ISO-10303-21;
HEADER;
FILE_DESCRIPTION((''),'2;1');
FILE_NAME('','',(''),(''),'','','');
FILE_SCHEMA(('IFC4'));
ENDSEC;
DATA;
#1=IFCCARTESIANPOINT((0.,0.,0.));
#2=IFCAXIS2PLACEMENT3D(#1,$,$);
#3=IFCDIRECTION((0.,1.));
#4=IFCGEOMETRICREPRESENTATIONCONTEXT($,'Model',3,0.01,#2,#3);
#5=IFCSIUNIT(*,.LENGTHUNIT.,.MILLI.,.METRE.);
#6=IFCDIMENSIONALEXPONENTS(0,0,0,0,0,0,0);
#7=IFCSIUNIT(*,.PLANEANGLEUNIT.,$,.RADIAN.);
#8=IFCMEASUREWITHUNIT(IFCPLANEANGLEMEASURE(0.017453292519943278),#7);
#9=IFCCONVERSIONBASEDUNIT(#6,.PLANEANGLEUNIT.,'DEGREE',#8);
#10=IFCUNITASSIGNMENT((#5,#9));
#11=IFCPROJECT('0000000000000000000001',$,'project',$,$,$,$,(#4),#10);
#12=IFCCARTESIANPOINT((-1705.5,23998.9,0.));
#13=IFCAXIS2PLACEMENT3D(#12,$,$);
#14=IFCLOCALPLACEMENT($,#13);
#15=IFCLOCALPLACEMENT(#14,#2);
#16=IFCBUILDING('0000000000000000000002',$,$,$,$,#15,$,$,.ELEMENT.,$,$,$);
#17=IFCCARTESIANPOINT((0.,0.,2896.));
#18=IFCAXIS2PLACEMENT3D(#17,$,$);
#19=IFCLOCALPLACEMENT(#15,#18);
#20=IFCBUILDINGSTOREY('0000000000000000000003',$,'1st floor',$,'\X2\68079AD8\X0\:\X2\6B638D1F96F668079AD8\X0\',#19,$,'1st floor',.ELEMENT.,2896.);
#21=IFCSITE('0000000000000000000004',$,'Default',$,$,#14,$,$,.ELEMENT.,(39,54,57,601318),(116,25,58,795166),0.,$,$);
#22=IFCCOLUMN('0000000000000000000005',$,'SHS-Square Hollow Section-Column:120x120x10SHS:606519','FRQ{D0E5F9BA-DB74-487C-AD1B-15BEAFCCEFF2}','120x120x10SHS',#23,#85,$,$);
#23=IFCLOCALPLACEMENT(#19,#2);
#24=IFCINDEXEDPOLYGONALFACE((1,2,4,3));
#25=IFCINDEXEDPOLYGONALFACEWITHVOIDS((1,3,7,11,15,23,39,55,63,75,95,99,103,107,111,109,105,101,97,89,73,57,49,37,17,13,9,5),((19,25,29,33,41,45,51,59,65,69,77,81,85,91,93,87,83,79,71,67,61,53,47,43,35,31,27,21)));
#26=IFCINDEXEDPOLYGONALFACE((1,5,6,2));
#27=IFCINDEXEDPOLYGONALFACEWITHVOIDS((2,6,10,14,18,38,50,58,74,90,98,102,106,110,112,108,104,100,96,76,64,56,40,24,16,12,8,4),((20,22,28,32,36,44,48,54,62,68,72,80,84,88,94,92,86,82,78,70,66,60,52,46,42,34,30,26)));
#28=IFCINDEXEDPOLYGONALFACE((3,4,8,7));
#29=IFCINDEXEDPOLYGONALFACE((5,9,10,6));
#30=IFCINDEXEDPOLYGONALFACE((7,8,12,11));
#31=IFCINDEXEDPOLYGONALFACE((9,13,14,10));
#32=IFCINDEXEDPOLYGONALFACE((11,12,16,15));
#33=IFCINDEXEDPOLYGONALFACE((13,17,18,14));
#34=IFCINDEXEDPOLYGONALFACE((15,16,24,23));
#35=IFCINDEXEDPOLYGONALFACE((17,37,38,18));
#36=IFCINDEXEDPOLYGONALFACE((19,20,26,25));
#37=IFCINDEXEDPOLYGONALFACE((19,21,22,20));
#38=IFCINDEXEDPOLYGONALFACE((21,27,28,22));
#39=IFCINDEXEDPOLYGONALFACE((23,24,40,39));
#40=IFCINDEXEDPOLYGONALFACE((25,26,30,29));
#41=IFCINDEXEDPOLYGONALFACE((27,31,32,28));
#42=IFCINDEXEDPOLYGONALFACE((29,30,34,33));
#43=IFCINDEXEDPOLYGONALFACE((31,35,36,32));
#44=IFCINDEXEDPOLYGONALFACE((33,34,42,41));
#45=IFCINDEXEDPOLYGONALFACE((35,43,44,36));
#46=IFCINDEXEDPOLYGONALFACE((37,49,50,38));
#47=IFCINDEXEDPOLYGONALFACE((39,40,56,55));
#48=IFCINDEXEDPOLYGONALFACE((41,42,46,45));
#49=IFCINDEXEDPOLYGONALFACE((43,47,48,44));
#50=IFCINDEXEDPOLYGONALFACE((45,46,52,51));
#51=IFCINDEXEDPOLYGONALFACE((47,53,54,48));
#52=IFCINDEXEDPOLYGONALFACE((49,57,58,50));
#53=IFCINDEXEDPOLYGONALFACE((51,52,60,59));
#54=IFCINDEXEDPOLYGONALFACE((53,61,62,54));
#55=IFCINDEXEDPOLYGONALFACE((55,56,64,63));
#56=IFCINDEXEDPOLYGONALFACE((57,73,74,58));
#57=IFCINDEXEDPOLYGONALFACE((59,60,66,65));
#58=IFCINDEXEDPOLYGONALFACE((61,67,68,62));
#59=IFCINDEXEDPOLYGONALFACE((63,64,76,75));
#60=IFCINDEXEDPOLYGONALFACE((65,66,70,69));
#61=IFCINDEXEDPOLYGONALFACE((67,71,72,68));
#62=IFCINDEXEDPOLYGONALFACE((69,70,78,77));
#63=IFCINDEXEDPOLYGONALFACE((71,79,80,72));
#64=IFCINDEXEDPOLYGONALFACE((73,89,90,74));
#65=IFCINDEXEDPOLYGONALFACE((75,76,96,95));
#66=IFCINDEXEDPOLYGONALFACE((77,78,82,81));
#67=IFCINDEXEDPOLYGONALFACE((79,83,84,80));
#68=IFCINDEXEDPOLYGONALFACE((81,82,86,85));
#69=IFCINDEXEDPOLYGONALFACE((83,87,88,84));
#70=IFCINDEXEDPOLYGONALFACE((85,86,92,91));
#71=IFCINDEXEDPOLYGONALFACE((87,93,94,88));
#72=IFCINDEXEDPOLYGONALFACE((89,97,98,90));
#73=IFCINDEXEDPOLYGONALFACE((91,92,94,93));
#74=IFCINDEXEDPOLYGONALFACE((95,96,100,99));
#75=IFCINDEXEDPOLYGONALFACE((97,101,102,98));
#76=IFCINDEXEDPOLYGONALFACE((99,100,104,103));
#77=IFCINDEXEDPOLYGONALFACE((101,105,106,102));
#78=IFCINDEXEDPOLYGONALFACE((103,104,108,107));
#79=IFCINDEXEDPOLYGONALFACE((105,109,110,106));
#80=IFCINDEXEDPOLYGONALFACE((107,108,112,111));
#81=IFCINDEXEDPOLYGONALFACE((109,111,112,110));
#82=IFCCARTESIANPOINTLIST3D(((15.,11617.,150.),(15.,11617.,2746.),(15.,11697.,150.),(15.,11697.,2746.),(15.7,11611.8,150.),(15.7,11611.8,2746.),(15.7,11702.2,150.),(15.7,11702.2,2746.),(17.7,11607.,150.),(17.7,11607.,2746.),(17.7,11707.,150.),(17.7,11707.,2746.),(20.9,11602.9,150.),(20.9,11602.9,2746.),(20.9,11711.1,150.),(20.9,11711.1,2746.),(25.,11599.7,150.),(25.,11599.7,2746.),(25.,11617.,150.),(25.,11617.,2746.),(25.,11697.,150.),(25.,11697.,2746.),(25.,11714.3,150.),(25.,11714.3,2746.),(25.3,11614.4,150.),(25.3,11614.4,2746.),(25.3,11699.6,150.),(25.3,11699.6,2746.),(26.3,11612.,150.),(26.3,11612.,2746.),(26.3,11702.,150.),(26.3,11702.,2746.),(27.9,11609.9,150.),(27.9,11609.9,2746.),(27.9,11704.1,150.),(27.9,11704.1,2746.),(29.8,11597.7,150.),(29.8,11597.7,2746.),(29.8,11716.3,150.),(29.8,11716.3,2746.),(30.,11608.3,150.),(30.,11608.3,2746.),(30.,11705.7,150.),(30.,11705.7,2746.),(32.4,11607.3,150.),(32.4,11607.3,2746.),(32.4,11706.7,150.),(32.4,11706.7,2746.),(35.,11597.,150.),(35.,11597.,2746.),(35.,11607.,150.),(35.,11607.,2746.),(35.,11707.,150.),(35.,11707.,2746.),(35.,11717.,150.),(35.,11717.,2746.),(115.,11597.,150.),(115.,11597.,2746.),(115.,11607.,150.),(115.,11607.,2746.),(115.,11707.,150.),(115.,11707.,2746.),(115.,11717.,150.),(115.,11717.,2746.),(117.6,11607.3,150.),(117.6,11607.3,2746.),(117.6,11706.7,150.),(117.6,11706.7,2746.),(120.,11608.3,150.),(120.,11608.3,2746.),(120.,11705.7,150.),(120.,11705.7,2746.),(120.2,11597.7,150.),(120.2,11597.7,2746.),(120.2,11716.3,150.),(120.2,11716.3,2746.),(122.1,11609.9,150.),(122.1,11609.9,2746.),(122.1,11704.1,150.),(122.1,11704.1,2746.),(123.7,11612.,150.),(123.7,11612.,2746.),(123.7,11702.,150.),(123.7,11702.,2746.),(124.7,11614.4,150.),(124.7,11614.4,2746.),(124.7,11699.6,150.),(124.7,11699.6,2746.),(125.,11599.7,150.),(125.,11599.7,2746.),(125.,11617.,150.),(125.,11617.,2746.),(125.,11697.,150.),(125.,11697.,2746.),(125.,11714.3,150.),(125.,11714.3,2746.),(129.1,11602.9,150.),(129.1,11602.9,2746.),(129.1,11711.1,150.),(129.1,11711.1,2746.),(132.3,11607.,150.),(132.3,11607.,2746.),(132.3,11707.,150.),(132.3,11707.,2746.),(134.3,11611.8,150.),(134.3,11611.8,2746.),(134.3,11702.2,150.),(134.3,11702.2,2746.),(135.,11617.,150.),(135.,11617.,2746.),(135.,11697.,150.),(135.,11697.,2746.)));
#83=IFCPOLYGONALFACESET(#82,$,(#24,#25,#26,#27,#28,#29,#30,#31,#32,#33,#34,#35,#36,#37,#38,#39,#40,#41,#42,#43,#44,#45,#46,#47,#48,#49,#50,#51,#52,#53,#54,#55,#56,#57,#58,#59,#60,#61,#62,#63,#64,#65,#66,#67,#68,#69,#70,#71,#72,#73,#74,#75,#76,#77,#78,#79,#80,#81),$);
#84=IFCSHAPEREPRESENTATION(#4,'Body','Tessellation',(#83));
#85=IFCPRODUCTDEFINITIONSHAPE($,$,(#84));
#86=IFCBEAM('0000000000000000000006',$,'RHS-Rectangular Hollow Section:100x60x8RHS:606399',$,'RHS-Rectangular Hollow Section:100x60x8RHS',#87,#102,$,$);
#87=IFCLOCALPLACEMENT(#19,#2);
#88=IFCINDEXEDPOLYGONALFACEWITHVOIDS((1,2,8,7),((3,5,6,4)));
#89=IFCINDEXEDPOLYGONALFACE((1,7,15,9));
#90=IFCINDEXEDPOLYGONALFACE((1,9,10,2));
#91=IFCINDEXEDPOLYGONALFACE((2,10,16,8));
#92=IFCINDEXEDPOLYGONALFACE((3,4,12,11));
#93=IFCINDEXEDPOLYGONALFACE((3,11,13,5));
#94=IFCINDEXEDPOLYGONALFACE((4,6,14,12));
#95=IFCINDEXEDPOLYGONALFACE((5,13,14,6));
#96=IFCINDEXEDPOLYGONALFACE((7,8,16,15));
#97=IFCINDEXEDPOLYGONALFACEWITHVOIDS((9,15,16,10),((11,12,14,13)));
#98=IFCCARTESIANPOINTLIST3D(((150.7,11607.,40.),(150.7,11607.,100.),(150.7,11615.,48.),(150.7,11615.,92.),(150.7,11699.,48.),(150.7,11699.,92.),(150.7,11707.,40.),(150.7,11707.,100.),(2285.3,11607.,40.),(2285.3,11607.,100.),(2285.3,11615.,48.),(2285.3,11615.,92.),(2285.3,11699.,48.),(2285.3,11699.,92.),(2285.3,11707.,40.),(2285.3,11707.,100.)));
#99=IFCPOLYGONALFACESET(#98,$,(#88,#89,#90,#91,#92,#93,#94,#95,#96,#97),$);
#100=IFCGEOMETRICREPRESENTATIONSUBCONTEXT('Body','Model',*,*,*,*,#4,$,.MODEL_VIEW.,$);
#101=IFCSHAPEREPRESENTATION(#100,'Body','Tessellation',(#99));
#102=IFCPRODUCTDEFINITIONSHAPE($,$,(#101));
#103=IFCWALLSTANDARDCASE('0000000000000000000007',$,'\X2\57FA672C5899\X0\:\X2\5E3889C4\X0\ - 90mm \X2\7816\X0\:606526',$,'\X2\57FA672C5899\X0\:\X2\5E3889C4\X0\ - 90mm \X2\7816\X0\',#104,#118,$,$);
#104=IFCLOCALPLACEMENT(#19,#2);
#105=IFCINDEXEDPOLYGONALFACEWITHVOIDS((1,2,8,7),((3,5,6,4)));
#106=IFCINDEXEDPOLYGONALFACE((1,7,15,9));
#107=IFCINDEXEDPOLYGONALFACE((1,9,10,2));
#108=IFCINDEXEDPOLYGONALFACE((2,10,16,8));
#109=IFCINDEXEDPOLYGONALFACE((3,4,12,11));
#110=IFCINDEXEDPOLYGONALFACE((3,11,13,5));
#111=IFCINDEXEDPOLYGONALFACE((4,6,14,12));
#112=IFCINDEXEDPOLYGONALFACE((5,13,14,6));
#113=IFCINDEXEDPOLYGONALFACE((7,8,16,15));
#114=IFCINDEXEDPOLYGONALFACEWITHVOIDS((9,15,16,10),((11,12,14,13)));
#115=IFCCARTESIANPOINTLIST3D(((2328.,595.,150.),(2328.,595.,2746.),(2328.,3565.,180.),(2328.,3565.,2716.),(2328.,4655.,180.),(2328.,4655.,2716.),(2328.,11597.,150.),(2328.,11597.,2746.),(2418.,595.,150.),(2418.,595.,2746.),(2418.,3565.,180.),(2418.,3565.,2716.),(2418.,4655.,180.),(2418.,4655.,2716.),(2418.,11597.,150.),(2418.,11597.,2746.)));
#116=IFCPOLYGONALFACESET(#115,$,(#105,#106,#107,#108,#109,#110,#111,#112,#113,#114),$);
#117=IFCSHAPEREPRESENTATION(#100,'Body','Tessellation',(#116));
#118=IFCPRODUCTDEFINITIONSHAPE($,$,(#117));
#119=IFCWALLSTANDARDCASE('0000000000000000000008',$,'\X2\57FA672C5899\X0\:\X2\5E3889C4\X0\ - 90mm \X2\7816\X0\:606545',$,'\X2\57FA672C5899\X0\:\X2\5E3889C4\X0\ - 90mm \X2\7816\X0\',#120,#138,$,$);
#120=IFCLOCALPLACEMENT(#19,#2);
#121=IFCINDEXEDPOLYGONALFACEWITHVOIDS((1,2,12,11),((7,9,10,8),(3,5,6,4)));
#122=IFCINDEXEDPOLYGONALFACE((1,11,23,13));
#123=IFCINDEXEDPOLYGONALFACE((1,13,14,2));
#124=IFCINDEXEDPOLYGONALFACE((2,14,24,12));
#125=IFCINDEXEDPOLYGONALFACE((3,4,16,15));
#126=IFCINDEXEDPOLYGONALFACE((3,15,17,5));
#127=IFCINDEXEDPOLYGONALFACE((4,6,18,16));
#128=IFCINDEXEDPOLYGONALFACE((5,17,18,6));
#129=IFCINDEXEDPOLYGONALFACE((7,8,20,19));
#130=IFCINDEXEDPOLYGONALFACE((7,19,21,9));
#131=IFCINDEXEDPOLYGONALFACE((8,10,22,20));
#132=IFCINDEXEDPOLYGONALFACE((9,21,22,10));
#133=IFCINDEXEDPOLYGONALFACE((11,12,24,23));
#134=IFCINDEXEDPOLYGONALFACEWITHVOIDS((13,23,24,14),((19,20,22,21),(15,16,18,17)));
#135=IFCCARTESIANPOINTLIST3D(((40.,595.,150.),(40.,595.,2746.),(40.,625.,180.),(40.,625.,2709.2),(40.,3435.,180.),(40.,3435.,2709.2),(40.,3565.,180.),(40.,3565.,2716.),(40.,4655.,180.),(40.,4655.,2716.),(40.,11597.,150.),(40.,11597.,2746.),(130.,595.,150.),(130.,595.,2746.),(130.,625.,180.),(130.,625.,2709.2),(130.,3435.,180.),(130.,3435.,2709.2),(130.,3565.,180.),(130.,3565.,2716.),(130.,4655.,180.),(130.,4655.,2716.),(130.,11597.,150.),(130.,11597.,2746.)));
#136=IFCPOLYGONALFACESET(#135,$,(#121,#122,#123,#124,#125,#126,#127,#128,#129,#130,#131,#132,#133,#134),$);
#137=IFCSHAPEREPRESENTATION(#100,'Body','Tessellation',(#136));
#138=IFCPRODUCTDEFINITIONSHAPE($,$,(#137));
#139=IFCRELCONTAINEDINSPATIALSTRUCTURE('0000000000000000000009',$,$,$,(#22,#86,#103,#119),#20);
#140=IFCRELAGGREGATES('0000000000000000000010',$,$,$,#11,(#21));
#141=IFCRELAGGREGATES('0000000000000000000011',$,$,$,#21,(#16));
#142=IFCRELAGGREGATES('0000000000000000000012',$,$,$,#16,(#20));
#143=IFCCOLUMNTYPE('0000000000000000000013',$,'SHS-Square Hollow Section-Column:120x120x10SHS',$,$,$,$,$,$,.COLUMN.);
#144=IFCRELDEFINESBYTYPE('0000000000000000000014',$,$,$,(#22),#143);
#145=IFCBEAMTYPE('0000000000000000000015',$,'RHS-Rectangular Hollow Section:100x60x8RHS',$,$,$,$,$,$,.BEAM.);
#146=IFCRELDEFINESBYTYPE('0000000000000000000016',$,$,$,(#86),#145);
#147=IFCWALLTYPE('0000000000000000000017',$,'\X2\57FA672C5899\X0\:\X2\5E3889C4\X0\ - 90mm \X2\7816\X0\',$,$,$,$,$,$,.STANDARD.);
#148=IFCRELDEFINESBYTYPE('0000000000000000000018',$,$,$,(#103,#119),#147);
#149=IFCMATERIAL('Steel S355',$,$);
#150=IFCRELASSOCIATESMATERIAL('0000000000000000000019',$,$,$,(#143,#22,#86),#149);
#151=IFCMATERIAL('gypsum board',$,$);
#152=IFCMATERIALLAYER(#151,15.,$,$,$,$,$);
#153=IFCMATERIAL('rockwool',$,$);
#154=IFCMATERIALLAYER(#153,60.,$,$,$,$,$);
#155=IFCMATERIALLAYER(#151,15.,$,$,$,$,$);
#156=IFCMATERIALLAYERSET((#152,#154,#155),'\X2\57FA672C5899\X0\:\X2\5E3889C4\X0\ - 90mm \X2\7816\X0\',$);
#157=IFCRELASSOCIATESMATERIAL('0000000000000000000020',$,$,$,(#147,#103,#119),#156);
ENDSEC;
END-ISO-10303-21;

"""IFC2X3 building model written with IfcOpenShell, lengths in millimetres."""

from ifc_helpers import new_model, entity, si_unit, converted_unit, direction, frame, frame_2d, origin, origin_2d, place, context, subcontext, project, spatial, rectangle, hollow_rectangle, extrude, boolean, clip, halfspace, material, layer, layer_set, layer_usage, type_object, element, save


model = new_model("IFC2X3")

# Units and contexts
model_context = context("Model", 3, precision=0.01, world=origin(), true_north=direction((0.0, 1.0)))
body_context = subcontext(model_context, "Body", "Model", "MODEL_VIEW")
ifc_project = project(units=[si_unit("LENGTHUNIT", "METRE", prefix="MILLI"), converted_unit("PLANEANGLEUNIT", "DEGREE", entity("IfcPlaneAngleMeasure", 0.017453292519943278), si_unit("PLANEANGLEUNIT", "RADIAN"), dimensions=[0, 0, 0, 0, 0, 0, 0])], contexts=[model_context])

# Site, building, storey
site_placement = place(None, frame((-1705.5, 23998.9, 0.0)))
site = spatial("IfcSite", under=ifc_project, at=site_placement, Name="Default", CompositionType="ELEMENT", RefLatitude=(39, 54, 57, 601318), RefLongitude=(116, 25, 58, 795166), RefElevation=0.0)
building_placement = place(site_placement, origin())
building = spatial("IfcBuilding", under=site, at=building_placement, CompositionType="ELEMENT")
storey_placement = place(building_placement, frame((0.0, 0.0, 2896.0)))
storey = spatial("IfcBuildingStorey", under=building, at=storey_placement, Name="1st floor", ObjectType="标高:正负零标高", LongName="1st floor", CompositionType="ELEMENT", Elevation=2896.0)

# Shared definitions
ifc_material_1 = material(Name="Steel S355")

# Column
column_type_1 = type_object("IfcColumnType", Name="SHS-Square Hollow Section-Column:120x120x10SHS", PredefinedType="COLUMN", material=ifc_material_1)
column_1_placement = place(storey_placement, frame((75.0, 11657.0, 2830.9), z_axis=(0.0, 0.0, 1.0), x_axis=(0.0, -1.0, 0.0)))
element("IfcColumn", 1, at=column_1_placement, inside=storey, type_object=column_type_1, material=ifc_material_1, Name="SHS-Square Hollow Section-Column:120x120x10SHS:606519", Description="FRQ{D0E5F9BA-DB74-487C-AD1B-15BEAFCCEFF2}", ObjectType="120x120x10SHS", context=model_context, shape_type="Clipping", body=[
    clip(clip(extrude(hollow_rectangle(XDim=120.0, YDim=120.0, WallThickness=10.0, InnerFilletRadius=10.0, OuterFilletRadius=20.0, at=origin_2d()), origin(), (0.0, 0.0, -1.0), 2765.7), halfspace(frame((11657.0, -75.0, -84.9), z_axis=(0.0, 0.0, -1.0), x_axis=(0.0, -1.0, 0.0)), True)), halfspace(frame((11657.0, -75.0, -2680.9), z_axis=(0.0, 0.0, 1.0), x_axis=(0.0, 1.0, 0.0)), True)),
])

# Beam
beam_type_1 = type_object("IfcBeamType", Name="RHS-Rectangular Hollow Section:100x60x8RHS", PredefinedType="BEAM")
beam_1_placement = place(storey_placement, frame((150.7, 11707.0, 70.0)))
element("IfcBeam", 2, at=beam_1_placement, inside=storey, type_object=beam_type_1, material=ifc_material_1, Name="RHS-Rectangular Hollow Section:100x60x8RHS:606399", ObjectType="RHS-Rectangular Hollow Section:100x60x8RHS", context=body_context, shape_type="SweptSolid", body=[
    boolean("DIFFERENCE", extrude(rectangle(XDim=60.0, YDim=100.0, at=frame_2d((0.0, 0.0), x_axis=(1.0, 0.0))), frame((0.0, -50.0, 0.0), z_axis=(1.0, 0.0, 0.0), x_axis=(0.0, 0.0, -1.0)), (0.0, 0.0, 1.0), 2134.6), extrude(rectangle(XDim=44.0, YDim=84.0, at=frame_2d((0.0, 0.0), x_axis=(0.0, 1.0))), frame((2134.6, -50.0, 0.0), z_axis=(-1.0, 0.0, 0.0), x_axis=(0.0, 1.0, 0.0)), (0.0, 0.0, 1.0), 2134.6)),
])

# Shared definitions
ifc_material_2 = material(Name="gypsum board")
ifc_layer_1 = layer(ifc_material_2, 15.0)
ifc_material_3 = material(Name="rockwool")
ifc_layer_2 = layer(ifc_material_3, 60.0)
ifc_layer_3 = layer(ifc_material_2, 15.0)
ifc_layer_set = layer_set([ifc_layer_1, ifc_layer_2, ifc_layer_3], Name="基本墙:常规 - 90mm 砖")
wall_type = type_object("IfcWallType", Name="基本墙:常规 - 90mm 砖", PredefinedType="STANDARD", material=ifc_layer_set)

# Wall, opening
ifc_layer_usage_1 = layer_usage(ifc_layer_set, "AXIS2", "NEGATIVE", 45.0)
wall_1_placement = place(storey_placement, frame((2373.0, 11597.0, 150.0), z_axis=(0.0, 0.0, 1.0), x_axis=(0.0, -1.0, 0.0)))
wall_1 = element("IfcWallStandardCase", 3, at=wall_1_placement, inside=storey, type_object=wall_type, material=ifc_layer_usage_1, Name="基本墙:常规 - 90mm 砖:606526", ObjectType="基本墙:常规 - 90mm 砖", context=body_context, shape_type="SweptSolid", body=[
    extrude(rectangle(XDim=11002.0, YDim=90.0, at=frame_2d((5501.0, 0.0), x_axis=(-1.0, 0.0))), origin(), (0.0, 0.0, 1.0), 2596.0),
])
opening_1_placement = place(wall_1_placement, origin())
element("IfcOpeningElement", 4, at=opening_1_placement, cuts=wall_1, ObjectType="Opening", context=body_context, shape_type="SweptSolid", body=[
    extrude(rectangle(XDim=2536.0, YDim=1090.0, at=frame_2d((0.0, 0.0), x_axis=(0.0, 1.0))), frame((7487.0, 45.0, 1298.0), z_axis=(0.0, -1.0, 0.0), x_axis=(-1.0, 0.0, 0.0)), (0.0, 0.0, 1.0), 90.0),
])

# Wall, openings
ifc_layer_usage_2 = layer_usage(ifc_layer_set, "AXIS2", "NEGATIVE", 45.0)
wall_2_placement = place(storey_placement, frame((85.0, 11597.0, 150.0), z_axis=(0.0, 0.0, 1.0), x_axis=(0.0, -1.0, 0.0)))
wall_2 = element("IfcWallStandardCase", 5, at=wall_2_placement, inside=storey, type_object=wall_type, material=ifc_layer_usage_2, Name="基本墙:常规 - 90mm 砖:606545", ObjectType="基本墙:常规 - 90mm 砖", context=body_context, shape_type="SweptSolid", body=[
    extrude(rectangle(XDim=11002.0, YDim=90.0, at=frame_2d((5501.0, 0.0), x_axis=(-1.0, 0.0))), origin(), (0.0, 0.0, 1.0), 2596.0),
])
opening_2_placement = place(wall_2_placement, origin())
element("IfcOpeningElement", 6, at=opening_2_placement, cuts=wall_2, ObjectType="Opening", context=body_context, shape_type="SweptSolid", body=[
    extrude(rectangle(XDim=2536.0, YDim=1090.0, at=frame_2d((0.0, 0.0), x_axis=(0.0, 1.0))), frame((7487.0, 45.0, 1298.0), z_axis=(0.0, -1.0, 0.0), x_axis=(-1.0, 0.0, 0.0)), (0.0, 0.0, 1.0), 90.0),
])
opening_3_placement = place(wall_2_placement, origin())
element("IfcOpeningElement", 7, at=opening_3_placement, cuts=wall_2, ObjectType="Opening", context=body_context, shape_type="SweptSolid", body=[
    extrude(rectangle(XDim=2529.2, YDim=2810.0, at=frame_2d((0.0, 0.0), x_axis=(0.0, 1.0))), frame((9567.0, 45.0, 1294.6), z_axis=(0.0, -1.0, 0.0), x_axis=(-1.0, 0.0, 0.0)), (0.0, 0.0, 1.0), 90.0),
])

save(model, "model.ifc")
